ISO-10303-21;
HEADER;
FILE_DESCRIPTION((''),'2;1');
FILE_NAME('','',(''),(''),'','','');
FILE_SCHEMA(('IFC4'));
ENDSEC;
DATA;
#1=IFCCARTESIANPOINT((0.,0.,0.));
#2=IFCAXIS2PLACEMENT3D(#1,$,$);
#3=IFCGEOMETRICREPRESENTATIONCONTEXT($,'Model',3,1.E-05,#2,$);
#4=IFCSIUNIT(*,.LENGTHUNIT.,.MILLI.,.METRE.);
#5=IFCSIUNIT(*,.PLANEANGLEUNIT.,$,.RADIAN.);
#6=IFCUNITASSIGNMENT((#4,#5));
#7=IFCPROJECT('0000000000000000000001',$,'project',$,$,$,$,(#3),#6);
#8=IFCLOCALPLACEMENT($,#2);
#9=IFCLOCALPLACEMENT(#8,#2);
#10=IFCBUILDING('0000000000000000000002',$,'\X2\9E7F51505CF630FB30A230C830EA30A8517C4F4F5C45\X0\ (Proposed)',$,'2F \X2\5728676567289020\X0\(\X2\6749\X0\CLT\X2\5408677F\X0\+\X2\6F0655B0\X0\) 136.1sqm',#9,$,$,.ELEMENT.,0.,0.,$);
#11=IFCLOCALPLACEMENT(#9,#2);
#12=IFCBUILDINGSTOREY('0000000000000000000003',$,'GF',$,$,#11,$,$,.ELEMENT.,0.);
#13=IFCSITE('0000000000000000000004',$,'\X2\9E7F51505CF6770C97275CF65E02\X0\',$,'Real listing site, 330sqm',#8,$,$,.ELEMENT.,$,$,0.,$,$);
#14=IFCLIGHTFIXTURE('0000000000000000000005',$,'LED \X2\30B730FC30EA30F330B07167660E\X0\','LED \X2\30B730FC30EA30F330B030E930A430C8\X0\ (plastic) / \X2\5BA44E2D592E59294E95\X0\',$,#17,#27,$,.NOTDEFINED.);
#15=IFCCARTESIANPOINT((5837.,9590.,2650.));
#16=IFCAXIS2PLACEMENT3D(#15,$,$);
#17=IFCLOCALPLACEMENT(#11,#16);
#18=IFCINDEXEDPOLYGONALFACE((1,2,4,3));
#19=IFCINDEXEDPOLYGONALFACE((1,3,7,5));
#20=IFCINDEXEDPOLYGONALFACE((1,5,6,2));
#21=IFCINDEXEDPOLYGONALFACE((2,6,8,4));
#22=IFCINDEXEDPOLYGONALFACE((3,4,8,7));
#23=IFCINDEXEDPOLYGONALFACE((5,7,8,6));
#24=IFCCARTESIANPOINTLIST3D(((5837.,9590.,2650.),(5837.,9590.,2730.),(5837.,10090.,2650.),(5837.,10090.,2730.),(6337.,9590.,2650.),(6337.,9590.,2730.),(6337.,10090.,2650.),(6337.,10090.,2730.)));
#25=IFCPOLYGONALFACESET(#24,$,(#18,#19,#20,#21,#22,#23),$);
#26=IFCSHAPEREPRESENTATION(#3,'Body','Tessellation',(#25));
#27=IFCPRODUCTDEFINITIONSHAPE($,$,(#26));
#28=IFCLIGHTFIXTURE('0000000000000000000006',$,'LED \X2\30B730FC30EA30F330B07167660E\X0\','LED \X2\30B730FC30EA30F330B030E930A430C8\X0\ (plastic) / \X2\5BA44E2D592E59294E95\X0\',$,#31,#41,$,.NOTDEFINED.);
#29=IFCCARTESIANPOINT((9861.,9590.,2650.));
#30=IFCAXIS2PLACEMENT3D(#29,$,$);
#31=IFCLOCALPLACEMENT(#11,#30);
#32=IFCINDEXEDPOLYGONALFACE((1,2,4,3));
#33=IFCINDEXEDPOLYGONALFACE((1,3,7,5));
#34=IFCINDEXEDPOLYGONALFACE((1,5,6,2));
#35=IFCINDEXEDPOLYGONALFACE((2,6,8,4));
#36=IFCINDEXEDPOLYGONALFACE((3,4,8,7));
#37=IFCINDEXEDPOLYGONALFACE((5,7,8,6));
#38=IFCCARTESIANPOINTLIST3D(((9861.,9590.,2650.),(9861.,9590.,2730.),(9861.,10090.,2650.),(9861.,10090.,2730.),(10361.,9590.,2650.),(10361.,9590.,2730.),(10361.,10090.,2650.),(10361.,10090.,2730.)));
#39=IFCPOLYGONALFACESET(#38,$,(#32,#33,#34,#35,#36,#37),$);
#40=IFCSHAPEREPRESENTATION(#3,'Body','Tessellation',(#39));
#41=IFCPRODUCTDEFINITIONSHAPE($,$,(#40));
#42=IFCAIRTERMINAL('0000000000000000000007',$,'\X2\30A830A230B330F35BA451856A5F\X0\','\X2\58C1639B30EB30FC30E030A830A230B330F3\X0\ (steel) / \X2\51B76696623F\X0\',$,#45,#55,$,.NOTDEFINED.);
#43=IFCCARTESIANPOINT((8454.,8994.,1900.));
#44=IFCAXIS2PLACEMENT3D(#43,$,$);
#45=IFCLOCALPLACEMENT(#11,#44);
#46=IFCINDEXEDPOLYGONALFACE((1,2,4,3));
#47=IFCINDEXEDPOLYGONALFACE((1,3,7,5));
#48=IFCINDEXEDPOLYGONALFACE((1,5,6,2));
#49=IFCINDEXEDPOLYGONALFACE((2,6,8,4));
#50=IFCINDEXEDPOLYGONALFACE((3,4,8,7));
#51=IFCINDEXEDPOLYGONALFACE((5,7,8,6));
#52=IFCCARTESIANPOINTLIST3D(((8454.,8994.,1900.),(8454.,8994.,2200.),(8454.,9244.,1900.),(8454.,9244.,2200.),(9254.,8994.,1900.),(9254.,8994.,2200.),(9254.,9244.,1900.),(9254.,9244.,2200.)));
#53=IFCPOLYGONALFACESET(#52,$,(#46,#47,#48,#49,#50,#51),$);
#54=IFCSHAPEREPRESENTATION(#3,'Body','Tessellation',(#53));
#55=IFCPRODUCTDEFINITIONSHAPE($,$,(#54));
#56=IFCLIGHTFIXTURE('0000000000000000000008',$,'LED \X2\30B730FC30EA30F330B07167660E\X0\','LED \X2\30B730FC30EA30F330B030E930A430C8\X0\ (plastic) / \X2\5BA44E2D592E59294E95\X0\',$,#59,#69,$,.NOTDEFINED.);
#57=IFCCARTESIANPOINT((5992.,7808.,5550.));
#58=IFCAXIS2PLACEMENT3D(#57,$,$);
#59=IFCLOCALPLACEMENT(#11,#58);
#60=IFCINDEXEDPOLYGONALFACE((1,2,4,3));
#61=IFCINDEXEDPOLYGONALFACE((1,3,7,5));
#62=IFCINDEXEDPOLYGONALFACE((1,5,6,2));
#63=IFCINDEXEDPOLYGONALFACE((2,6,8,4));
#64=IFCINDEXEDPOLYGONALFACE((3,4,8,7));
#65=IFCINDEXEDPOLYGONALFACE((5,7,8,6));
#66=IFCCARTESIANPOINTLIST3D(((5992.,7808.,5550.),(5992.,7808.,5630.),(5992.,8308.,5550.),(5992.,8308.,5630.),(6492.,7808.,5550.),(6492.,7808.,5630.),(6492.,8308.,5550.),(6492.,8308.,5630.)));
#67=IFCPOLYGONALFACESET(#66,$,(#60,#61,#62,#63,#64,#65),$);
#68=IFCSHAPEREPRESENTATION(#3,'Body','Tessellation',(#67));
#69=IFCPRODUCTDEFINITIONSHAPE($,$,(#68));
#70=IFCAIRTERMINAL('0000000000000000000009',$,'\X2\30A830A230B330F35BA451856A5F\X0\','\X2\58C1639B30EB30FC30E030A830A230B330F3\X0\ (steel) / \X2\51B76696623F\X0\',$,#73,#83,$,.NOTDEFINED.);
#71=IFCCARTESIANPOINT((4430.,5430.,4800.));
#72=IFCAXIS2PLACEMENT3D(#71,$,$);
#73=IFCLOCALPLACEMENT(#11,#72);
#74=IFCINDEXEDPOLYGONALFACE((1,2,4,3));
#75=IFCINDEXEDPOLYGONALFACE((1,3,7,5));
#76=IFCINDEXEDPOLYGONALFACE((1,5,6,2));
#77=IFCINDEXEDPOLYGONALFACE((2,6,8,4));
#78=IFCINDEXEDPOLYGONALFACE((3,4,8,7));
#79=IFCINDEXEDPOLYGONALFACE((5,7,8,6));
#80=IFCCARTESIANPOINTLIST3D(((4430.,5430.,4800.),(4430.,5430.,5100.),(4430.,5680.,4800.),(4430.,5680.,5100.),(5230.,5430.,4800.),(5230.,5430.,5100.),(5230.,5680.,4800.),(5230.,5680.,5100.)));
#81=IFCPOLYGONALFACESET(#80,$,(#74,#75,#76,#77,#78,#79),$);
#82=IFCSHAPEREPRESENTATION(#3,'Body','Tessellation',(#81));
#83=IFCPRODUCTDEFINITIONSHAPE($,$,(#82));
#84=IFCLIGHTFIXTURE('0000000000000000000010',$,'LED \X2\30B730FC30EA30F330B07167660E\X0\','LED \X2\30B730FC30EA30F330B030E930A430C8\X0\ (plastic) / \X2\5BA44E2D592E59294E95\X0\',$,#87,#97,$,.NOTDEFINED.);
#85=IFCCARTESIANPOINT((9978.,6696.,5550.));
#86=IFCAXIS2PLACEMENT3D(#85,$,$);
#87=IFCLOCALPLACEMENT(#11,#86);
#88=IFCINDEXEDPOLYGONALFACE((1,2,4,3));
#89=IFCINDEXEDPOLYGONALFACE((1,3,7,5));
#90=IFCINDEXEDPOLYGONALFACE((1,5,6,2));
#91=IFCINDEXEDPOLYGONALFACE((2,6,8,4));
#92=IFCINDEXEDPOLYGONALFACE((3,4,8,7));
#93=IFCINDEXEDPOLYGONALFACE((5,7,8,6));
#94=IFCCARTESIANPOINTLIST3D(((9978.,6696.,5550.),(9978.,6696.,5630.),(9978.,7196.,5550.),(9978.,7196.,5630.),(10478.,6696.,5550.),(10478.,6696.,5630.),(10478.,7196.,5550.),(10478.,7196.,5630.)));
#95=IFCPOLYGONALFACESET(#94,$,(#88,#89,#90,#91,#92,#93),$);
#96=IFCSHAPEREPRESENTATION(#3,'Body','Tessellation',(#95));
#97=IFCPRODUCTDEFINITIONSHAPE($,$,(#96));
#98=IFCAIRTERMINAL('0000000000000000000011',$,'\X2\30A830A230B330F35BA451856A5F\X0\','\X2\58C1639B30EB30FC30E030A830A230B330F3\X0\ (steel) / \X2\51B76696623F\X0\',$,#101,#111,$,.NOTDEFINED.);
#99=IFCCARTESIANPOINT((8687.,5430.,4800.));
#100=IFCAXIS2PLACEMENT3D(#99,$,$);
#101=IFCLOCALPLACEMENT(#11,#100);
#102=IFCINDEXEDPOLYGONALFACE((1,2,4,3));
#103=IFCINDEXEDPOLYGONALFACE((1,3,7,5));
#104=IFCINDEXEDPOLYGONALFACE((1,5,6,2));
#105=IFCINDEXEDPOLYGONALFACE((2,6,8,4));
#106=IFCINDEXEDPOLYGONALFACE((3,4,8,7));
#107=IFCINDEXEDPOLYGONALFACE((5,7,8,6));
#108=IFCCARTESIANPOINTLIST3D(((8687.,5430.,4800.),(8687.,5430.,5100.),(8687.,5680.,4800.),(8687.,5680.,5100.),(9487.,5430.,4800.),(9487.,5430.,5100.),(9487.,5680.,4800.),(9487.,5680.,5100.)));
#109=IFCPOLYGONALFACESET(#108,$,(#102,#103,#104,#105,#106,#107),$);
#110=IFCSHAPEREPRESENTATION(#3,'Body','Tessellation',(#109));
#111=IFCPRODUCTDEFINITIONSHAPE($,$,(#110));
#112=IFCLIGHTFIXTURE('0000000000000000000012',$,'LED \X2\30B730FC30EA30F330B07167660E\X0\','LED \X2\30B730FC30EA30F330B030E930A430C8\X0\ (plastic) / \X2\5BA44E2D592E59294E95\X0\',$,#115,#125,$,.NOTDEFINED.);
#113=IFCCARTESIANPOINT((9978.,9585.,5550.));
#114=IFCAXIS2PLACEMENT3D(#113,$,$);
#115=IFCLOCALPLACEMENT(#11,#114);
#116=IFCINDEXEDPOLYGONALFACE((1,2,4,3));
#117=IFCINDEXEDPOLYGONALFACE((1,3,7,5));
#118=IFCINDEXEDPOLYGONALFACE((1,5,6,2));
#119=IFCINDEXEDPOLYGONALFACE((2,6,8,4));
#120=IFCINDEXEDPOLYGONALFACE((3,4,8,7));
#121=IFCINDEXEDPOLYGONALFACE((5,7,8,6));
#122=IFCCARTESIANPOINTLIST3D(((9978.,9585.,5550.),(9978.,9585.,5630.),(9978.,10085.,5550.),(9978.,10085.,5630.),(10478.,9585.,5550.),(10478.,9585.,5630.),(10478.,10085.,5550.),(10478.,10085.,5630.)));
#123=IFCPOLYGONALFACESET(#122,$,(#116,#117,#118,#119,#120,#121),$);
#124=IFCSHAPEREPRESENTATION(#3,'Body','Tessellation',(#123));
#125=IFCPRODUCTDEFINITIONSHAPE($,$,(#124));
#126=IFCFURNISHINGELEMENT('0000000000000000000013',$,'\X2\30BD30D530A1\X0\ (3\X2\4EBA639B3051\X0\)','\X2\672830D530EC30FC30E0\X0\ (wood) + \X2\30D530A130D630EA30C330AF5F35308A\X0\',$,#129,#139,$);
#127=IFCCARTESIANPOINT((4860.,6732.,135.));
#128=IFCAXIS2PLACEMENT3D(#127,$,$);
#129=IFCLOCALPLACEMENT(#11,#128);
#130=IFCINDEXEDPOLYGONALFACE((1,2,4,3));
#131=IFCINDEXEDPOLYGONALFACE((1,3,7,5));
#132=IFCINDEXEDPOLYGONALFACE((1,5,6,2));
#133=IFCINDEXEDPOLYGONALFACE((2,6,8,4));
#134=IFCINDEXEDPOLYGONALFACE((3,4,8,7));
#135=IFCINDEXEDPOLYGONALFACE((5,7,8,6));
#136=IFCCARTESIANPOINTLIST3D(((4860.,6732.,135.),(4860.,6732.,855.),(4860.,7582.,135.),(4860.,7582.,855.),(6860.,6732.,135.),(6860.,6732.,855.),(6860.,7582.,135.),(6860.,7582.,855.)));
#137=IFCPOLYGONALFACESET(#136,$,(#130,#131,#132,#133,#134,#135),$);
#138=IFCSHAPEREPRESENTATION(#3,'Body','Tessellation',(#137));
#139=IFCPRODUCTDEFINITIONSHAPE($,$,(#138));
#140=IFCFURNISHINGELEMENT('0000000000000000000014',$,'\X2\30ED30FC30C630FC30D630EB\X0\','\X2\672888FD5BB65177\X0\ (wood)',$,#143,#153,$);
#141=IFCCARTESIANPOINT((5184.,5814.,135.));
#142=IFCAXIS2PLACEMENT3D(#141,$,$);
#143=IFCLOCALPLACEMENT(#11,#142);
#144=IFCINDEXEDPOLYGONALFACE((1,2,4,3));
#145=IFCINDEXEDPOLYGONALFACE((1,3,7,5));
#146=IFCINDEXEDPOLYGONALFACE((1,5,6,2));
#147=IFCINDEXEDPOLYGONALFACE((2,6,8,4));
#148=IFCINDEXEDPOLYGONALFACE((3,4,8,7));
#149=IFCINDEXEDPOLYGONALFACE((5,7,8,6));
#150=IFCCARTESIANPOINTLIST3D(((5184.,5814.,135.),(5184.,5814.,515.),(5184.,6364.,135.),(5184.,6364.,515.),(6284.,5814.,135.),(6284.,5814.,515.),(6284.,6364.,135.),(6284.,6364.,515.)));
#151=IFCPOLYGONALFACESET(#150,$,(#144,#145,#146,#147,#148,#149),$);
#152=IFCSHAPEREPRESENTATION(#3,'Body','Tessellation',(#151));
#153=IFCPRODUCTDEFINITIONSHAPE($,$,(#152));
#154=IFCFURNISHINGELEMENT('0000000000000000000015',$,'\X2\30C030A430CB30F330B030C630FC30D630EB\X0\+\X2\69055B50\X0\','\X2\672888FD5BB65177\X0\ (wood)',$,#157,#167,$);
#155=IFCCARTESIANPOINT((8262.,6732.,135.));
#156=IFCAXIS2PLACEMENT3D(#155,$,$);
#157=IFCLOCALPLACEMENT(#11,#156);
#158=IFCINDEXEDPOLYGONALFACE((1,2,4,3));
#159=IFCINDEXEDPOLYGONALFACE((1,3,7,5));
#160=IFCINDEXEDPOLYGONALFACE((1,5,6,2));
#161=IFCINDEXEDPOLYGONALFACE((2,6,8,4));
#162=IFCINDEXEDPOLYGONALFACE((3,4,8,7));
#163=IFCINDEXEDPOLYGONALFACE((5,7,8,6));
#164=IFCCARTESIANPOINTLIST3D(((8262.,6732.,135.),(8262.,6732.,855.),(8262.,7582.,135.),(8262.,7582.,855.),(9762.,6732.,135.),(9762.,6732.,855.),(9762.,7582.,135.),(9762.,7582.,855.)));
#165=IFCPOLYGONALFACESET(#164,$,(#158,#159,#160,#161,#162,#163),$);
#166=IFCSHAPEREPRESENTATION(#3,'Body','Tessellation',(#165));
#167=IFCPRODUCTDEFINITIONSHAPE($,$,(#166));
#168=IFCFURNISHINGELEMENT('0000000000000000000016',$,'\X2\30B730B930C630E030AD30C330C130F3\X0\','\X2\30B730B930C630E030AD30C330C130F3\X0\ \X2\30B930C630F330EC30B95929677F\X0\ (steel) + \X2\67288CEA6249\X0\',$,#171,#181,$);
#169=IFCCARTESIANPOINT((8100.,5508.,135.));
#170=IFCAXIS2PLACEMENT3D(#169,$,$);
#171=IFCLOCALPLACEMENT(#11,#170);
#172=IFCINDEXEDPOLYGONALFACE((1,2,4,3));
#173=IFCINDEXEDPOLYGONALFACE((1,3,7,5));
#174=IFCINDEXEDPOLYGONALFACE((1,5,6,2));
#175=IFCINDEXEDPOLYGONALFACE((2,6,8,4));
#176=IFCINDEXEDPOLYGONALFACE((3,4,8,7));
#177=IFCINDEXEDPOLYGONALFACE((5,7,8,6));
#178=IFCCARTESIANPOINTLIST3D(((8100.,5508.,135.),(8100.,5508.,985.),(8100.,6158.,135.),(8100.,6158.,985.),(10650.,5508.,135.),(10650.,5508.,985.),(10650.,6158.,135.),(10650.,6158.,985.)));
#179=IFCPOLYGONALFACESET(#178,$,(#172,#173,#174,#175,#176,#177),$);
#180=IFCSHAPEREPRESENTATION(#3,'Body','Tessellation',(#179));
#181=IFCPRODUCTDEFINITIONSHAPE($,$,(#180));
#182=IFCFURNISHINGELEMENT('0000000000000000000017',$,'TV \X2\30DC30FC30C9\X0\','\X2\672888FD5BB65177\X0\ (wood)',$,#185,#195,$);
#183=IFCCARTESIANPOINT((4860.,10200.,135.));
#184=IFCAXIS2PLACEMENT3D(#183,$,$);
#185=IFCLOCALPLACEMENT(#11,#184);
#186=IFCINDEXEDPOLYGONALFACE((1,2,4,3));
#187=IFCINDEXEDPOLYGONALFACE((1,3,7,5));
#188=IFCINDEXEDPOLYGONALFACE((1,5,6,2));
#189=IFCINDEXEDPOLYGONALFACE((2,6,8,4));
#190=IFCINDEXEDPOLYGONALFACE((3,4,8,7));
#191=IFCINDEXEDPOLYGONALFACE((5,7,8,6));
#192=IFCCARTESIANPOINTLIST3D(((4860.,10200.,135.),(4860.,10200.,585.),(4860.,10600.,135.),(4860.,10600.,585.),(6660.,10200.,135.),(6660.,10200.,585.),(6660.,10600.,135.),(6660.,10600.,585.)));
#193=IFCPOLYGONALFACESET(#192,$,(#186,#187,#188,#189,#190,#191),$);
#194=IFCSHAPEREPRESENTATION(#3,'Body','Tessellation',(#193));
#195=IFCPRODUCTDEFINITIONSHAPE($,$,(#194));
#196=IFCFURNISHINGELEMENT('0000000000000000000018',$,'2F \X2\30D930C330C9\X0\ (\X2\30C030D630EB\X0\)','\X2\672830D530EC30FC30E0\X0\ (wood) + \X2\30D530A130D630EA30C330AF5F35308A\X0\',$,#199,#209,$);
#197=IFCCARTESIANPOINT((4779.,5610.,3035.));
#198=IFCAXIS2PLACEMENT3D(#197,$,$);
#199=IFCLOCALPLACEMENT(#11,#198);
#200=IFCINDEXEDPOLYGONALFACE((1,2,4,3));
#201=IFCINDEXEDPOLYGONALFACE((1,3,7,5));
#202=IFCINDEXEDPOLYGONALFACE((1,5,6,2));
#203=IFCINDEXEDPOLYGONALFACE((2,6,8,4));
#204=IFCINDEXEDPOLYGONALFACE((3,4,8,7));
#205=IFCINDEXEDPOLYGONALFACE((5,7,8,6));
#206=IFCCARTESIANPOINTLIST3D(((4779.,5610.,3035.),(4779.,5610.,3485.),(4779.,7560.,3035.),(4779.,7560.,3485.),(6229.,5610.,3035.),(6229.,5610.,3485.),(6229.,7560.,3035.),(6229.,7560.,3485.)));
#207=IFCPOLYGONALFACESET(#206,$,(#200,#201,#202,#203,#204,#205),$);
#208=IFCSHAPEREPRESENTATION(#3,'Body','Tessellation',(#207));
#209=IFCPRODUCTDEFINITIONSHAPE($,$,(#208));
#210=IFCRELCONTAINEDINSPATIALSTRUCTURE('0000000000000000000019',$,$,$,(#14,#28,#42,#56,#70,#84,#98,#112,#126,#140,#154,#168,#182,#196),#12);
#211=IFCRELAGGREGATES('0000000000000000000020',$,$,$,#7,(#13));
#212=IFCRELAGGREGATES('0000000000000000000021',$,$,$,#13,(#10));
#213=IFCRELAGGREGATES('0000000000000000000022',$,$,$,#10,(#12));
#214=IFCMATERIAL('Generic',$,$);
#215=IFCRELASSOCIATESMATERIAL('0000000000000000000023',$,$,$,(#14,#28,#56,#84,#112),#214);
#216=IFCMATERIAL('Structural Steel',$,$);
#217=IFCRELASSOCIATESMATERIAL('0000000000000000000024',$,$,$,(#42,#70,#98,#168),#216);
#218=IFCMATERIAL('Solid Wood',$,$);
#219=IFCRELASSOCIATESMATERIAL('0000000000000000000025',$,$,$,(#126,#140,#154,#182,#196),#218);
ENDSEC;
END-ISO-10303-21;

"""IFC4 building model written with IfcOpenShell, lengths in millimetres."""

from ifc_helpers import new_model, si_unit, frame, frame_2d, origin, place, context, project, spatial, rectangle, extrude, material, element, save


model = new_model("IFC4")

# Units and contexts
model_context = context("Model", 3, precision=1e-05, world=origin())
ifc_project = project(units=[si_unit("LENGTHUNIT", "METRE", prefix="MILLI"), si_unit("PLANEANGLEUNIT", "RADIAN")], contexts=[model_context])

# Site, building, storey
site_placement = place(None, origin())
site = spatial("IfcSite", under=ifc_project, at=site_placement, Name="鹿児島県霧島市", ObjectType="Real listing site, 330sqm", CompositionType="ELEMENT", RefElevation=0.0)
building_placement = place(site_placement, origin())
building = spatial("IfcBuilding", under=site, at=building_placement, Name="鹿児島・アトリエ兼住居 (Proposed)", ObjectType="2F 在来木造(杉CLT合板+漆喰) 136.1sqm", CompositionType="ELEMENT", ElevationOfRefHeight=0.0, ElevationOfTerrain=0.0)
storey_placement = place(building_placement, origin())
storey = spatial("IfcBuildingStorey", under=building, at=storey_placement, Name="GF", CompositionType="ELEMENT", Elevation=0.0)

# Shared definitions
ifc_material_1 = material(Name="Solid Wood")

# Shared definitions
ifc_material_2 = material(Name="Structural Steel")

# Shared definitions
ifc_material_3 = material(Name="Generic")

# Light fixtures
light_fixture_1_placement = place(storey_placement, frame((5837.0, 9590.0, 2650.0)))
element("IfcLightFixture", 1, at=light_fixture_1_placement, inside=storey, material=ifc_material_3, Name="LED シーリング照明", Description="LED シーリングライト (plastic) / 室中央天井", PredefinedType="NOTDEFINED", context=model_context, shape_type="SweptSolid", body=[
    extrude(rectangle(XDim=500.0, YDim=500.0, at=frame_2d((250.0, 250.0))), frame((5837.0, 9590.0, 2650.0)), (0.0, 0.0, 1.0), 80.0),
])
light_fixture_2_placement = place(storey_placement, frame((9861.0, 9590.0, 2650.0)))
element("IfcLightFixture", 2, at=light_fixture_2_placement, inside=storey, material=ifc_material_3, Name="LED シーリング照明", Description="LED シーリングライト (plastic) / 室中央天井", PredefinedType="NOTDEFINED", context=model_context, shape_type="SweptSolid", body=[
    extrude(rectangle(XDim=500.0, YDim=500.0, at=frame_2d((250.0, 250.0))), frame((9861.0, 9590.0, 2650.0)), (0.0, 0.0, 1.0), 80.0),
])

# Air terminal
air_terminal_1_placement = place(storey_placement, frame((8454.0, 8994.0, 1900.0)))
element("IfcAirTerminal", 3, at=air_terminal_1_placement, inside=storey, material=ifc_material_2, Name="エアコン室内機", Description="壁掛ルームエアコン (steel) / 冷暖房", PredefinedType="NOTDEFINED", context=model_context, shape_type="SweptSolid", body=[
    extrude(rectangle(XDim=800.0, YDim=250.0, at=frame_2d((400.0, 125.0))), frame((8454.0, 8994.0, 1900.0)), (0.0, 0.0, 1.0), 300.0),
])

# Light fixture
light_fixture_3_placement = place(storey_placement, frame((5992.0, 7808.0, 5550.0)))
element("IfcLightFixture", 4, at=light_fixture_3_placement, inside=storey, material=ifc_material_3, Name="LED シーリング照明", Description="LED シーリングライト (plastic) / 室中央天井", PredefinedType="NOTDEFINED", context=model_context, shape_type="SweptSolid", body=[
    extrude(rectangle(XDim=500.0, YDim=500.0, at=frame_2d((250.0, 250.0))), frame((5992.0, 7808.0, 5550.0)), (0.0, 0.0, 1.0), 80.0),
])

# Air terminal
air_terminal_2_placement = place(storey_placement, frame((4430.0, 5430.0, 4800.0)))
element("IfcAirTerminal", 5, at=air_terminal_2_placement, inside=storey, material=ifc_material_2, Name="エアコン室内機", Description="壁掛ルームエアコン (steel) / 冷暖房", PredefinedType="NOTDEFINED", context=model_context, shape_type="SweptSolid", body=[
    extrude(rectangle(XDim=800.0, YDim=250.0, at=frame_2d((400.0, 125.0))), frame((4430.0, 5430.0, 4800.0)), (0.0, 0.0, 1.0), 300.0),
])

# Light fixture
light_fixture_4_placement = place(storey_placement, frame((9978.0, 6696.0, 5550.0)))
element("IfcLightFixture", 6, at=light_fixture_4_placement, inside=storey, material=ifc_material_3, Name="LED シーリング照明", Description="LED シーリングライト (plastic) / 室中央天井", PredefinedType="NOTDEFINED", context=model_context, shape_type="SweptSolid", body=[
    extrude(rectangle(XDim=500.0, YDim=500.0, at=frame_2d((250.0, 250.0))), frame((9978.0, 6696.0, 5550.0)), (0.0, 0.0, 1.0), 80.0),
])

# Air terminal
air_terminal_3_placement = place(storey_placement, frame((8687.0, 5430.0, 4800.0)))
element("IfcAirTerminal", 7, at=air_terminal_3_placement, inside=storey, material=ifc_material_2, Name="エアコン室内機", Description="壁掛ルームエアコン (steel) / 冷暖房", PredefinedType="NOTDEFINED", context=model_context, shape_type="SweptSolid", body=[
    extrude(rectangle(XDim=800.0, YDim=250.0, at=frame_2d((400.0, 125.0))), frame((8687.0, 5430.0, 4800.0)), (0.0, 0.0, 1.0), 300.0),
])

# Light fixture
light_fixture_5_placement = place(storey_placement, frame((9978.0, 9585.0, 5550.0)))
element("IfcLightFixture", 8, at=light_fixture_5_placement, inside=storey, material=ifc_material_3, Name="LED シーリング照明", Description="LED シーリングライト (plastic) / 室中央天井", PredefinedType="NOTDEFINED", context=model_context, shape_type="SweptSolid", body=[
    extrude(rectangle(XDim=500.0, YDim=500.0, at=frame_2d((250.0, 250.0))), frame((9978.0, 9585.0, 5550.0)), (0.0, 0.0, 1.0), 80.0),
])

# Furnishing elements
furnishing_1_placement = place(storey_placement, frame((4860.0, 6732.0, 135.0)))
element("IfcFurnishingElement", 9, at=furnishing_1_placement, inside=storey, material=ifc_material_1, Name="ソファ (3人掛け)", Description="木フレーム (wood) + ファブリック張り", context=model_context, shape_type="SweptSolid", body=[
    extrude(rectangle(XDim=2000.0, YDim=850.0, at=frame_2d((1000.0, 425.0))), frame((4860.0, 6732.0, 135.0)), (0.0, 0.0, 1.0), 720.0),
])
furnishing_2_placement = place(storey_placement, frame((5184.0, 5814.0, 135.0)))
element("IfcFurnishingElement", 10, at=furnishing_2_placement, inside=storey, material=ifc_material_1, Name="ローテーブル", Description="木製家具 (wood)", context=model_context, shape_type="SweptSolid", body=[
    extrude(rectangle(XDim=1100.0, YDim=550.0, at=frame_2d((550.0, 275.0))), frame((5184.0, 5814.0, 135.0)), (0.0, 0.0, 1.0), 380.0),
])
furnishing_3_placement = place(storey_placement, frame((8262.0, 6732.0, 135.0)))
element("IfcFurnishingElement", 11, at=furnishing_3_placement, inside=storey, material=ifc_material_1, Name="ダイニングテーブル+椅子", Description="木製家具 (wood)", context=model_context, shape_type="SweptSolid", body=[
    extrude(rectangle(XDim=1500.0, YDim=850.0, at=frame_2d((750.0, 425.0))), frame((8262.0, 6732.0, 135.0)), (0.0, 0.0, 1.0), 720.0),
])
furnishing_4_placement = place(storey_placement, frame((8100.0, 5508.0, 135.0)))
element("IfcFurnishingElement", 12, at=furnishing_4_placement, inside=storey, material=ifc_material_2, Name="システムキッチン", Description="システムキッチン ステンレス天板 (steel) + 木質扉", context=model_context, shape_type="SweptSolid", body=[
    extrude(rectangle(XDim=2550.0, YDim=650.0, at=frame_2d((1275.0, 325.0))), frame((8100.0, 5508.0, 135.0)), (0.0, 0.0, 1.0), 850.0),
])
furnishing_5_placement = place(storey_placement, frame((4860.0, 10200.0, 135.0)))
element("IfcFurnishingElement", 13, at=furnishing_5_placement, inside=storey, material=ifc_material_1, Name="TV ボード", Description="木製家具 (wood)", context=model_context, shape_type="SweptSolid", body=[
    extrude(rectangle(XDim=1800.0, YDim=400.0, at=frame_2d((900.0, 200.0))), frame((4860.0, 10200.0, 135.0)), (0.0, 0.0, 1.0), 450.0),
])
furnishing_6_placement = place(storey_placement, frame((4779.0, 5610.0, 3035.0)))
element("IfcFurnishingElement", 14, at=furnishing_6_placement, inside=storey, material=ifc_material_1, Name="2F ベッド (ダブル)", Description="木フレーム (wood) + ファブリック張り", context=model_context, shape_type="SweptSolid", body=[
    extrude(rectangle(XDim=1450.0, YDim=1950.0, at=frame_2d((725.0, 975.0))), frame((4779.0, 5610.0, 3035.0)), (0.0, 0.0, 1.0), 450.0),
])

save(model, "model.ifc")
